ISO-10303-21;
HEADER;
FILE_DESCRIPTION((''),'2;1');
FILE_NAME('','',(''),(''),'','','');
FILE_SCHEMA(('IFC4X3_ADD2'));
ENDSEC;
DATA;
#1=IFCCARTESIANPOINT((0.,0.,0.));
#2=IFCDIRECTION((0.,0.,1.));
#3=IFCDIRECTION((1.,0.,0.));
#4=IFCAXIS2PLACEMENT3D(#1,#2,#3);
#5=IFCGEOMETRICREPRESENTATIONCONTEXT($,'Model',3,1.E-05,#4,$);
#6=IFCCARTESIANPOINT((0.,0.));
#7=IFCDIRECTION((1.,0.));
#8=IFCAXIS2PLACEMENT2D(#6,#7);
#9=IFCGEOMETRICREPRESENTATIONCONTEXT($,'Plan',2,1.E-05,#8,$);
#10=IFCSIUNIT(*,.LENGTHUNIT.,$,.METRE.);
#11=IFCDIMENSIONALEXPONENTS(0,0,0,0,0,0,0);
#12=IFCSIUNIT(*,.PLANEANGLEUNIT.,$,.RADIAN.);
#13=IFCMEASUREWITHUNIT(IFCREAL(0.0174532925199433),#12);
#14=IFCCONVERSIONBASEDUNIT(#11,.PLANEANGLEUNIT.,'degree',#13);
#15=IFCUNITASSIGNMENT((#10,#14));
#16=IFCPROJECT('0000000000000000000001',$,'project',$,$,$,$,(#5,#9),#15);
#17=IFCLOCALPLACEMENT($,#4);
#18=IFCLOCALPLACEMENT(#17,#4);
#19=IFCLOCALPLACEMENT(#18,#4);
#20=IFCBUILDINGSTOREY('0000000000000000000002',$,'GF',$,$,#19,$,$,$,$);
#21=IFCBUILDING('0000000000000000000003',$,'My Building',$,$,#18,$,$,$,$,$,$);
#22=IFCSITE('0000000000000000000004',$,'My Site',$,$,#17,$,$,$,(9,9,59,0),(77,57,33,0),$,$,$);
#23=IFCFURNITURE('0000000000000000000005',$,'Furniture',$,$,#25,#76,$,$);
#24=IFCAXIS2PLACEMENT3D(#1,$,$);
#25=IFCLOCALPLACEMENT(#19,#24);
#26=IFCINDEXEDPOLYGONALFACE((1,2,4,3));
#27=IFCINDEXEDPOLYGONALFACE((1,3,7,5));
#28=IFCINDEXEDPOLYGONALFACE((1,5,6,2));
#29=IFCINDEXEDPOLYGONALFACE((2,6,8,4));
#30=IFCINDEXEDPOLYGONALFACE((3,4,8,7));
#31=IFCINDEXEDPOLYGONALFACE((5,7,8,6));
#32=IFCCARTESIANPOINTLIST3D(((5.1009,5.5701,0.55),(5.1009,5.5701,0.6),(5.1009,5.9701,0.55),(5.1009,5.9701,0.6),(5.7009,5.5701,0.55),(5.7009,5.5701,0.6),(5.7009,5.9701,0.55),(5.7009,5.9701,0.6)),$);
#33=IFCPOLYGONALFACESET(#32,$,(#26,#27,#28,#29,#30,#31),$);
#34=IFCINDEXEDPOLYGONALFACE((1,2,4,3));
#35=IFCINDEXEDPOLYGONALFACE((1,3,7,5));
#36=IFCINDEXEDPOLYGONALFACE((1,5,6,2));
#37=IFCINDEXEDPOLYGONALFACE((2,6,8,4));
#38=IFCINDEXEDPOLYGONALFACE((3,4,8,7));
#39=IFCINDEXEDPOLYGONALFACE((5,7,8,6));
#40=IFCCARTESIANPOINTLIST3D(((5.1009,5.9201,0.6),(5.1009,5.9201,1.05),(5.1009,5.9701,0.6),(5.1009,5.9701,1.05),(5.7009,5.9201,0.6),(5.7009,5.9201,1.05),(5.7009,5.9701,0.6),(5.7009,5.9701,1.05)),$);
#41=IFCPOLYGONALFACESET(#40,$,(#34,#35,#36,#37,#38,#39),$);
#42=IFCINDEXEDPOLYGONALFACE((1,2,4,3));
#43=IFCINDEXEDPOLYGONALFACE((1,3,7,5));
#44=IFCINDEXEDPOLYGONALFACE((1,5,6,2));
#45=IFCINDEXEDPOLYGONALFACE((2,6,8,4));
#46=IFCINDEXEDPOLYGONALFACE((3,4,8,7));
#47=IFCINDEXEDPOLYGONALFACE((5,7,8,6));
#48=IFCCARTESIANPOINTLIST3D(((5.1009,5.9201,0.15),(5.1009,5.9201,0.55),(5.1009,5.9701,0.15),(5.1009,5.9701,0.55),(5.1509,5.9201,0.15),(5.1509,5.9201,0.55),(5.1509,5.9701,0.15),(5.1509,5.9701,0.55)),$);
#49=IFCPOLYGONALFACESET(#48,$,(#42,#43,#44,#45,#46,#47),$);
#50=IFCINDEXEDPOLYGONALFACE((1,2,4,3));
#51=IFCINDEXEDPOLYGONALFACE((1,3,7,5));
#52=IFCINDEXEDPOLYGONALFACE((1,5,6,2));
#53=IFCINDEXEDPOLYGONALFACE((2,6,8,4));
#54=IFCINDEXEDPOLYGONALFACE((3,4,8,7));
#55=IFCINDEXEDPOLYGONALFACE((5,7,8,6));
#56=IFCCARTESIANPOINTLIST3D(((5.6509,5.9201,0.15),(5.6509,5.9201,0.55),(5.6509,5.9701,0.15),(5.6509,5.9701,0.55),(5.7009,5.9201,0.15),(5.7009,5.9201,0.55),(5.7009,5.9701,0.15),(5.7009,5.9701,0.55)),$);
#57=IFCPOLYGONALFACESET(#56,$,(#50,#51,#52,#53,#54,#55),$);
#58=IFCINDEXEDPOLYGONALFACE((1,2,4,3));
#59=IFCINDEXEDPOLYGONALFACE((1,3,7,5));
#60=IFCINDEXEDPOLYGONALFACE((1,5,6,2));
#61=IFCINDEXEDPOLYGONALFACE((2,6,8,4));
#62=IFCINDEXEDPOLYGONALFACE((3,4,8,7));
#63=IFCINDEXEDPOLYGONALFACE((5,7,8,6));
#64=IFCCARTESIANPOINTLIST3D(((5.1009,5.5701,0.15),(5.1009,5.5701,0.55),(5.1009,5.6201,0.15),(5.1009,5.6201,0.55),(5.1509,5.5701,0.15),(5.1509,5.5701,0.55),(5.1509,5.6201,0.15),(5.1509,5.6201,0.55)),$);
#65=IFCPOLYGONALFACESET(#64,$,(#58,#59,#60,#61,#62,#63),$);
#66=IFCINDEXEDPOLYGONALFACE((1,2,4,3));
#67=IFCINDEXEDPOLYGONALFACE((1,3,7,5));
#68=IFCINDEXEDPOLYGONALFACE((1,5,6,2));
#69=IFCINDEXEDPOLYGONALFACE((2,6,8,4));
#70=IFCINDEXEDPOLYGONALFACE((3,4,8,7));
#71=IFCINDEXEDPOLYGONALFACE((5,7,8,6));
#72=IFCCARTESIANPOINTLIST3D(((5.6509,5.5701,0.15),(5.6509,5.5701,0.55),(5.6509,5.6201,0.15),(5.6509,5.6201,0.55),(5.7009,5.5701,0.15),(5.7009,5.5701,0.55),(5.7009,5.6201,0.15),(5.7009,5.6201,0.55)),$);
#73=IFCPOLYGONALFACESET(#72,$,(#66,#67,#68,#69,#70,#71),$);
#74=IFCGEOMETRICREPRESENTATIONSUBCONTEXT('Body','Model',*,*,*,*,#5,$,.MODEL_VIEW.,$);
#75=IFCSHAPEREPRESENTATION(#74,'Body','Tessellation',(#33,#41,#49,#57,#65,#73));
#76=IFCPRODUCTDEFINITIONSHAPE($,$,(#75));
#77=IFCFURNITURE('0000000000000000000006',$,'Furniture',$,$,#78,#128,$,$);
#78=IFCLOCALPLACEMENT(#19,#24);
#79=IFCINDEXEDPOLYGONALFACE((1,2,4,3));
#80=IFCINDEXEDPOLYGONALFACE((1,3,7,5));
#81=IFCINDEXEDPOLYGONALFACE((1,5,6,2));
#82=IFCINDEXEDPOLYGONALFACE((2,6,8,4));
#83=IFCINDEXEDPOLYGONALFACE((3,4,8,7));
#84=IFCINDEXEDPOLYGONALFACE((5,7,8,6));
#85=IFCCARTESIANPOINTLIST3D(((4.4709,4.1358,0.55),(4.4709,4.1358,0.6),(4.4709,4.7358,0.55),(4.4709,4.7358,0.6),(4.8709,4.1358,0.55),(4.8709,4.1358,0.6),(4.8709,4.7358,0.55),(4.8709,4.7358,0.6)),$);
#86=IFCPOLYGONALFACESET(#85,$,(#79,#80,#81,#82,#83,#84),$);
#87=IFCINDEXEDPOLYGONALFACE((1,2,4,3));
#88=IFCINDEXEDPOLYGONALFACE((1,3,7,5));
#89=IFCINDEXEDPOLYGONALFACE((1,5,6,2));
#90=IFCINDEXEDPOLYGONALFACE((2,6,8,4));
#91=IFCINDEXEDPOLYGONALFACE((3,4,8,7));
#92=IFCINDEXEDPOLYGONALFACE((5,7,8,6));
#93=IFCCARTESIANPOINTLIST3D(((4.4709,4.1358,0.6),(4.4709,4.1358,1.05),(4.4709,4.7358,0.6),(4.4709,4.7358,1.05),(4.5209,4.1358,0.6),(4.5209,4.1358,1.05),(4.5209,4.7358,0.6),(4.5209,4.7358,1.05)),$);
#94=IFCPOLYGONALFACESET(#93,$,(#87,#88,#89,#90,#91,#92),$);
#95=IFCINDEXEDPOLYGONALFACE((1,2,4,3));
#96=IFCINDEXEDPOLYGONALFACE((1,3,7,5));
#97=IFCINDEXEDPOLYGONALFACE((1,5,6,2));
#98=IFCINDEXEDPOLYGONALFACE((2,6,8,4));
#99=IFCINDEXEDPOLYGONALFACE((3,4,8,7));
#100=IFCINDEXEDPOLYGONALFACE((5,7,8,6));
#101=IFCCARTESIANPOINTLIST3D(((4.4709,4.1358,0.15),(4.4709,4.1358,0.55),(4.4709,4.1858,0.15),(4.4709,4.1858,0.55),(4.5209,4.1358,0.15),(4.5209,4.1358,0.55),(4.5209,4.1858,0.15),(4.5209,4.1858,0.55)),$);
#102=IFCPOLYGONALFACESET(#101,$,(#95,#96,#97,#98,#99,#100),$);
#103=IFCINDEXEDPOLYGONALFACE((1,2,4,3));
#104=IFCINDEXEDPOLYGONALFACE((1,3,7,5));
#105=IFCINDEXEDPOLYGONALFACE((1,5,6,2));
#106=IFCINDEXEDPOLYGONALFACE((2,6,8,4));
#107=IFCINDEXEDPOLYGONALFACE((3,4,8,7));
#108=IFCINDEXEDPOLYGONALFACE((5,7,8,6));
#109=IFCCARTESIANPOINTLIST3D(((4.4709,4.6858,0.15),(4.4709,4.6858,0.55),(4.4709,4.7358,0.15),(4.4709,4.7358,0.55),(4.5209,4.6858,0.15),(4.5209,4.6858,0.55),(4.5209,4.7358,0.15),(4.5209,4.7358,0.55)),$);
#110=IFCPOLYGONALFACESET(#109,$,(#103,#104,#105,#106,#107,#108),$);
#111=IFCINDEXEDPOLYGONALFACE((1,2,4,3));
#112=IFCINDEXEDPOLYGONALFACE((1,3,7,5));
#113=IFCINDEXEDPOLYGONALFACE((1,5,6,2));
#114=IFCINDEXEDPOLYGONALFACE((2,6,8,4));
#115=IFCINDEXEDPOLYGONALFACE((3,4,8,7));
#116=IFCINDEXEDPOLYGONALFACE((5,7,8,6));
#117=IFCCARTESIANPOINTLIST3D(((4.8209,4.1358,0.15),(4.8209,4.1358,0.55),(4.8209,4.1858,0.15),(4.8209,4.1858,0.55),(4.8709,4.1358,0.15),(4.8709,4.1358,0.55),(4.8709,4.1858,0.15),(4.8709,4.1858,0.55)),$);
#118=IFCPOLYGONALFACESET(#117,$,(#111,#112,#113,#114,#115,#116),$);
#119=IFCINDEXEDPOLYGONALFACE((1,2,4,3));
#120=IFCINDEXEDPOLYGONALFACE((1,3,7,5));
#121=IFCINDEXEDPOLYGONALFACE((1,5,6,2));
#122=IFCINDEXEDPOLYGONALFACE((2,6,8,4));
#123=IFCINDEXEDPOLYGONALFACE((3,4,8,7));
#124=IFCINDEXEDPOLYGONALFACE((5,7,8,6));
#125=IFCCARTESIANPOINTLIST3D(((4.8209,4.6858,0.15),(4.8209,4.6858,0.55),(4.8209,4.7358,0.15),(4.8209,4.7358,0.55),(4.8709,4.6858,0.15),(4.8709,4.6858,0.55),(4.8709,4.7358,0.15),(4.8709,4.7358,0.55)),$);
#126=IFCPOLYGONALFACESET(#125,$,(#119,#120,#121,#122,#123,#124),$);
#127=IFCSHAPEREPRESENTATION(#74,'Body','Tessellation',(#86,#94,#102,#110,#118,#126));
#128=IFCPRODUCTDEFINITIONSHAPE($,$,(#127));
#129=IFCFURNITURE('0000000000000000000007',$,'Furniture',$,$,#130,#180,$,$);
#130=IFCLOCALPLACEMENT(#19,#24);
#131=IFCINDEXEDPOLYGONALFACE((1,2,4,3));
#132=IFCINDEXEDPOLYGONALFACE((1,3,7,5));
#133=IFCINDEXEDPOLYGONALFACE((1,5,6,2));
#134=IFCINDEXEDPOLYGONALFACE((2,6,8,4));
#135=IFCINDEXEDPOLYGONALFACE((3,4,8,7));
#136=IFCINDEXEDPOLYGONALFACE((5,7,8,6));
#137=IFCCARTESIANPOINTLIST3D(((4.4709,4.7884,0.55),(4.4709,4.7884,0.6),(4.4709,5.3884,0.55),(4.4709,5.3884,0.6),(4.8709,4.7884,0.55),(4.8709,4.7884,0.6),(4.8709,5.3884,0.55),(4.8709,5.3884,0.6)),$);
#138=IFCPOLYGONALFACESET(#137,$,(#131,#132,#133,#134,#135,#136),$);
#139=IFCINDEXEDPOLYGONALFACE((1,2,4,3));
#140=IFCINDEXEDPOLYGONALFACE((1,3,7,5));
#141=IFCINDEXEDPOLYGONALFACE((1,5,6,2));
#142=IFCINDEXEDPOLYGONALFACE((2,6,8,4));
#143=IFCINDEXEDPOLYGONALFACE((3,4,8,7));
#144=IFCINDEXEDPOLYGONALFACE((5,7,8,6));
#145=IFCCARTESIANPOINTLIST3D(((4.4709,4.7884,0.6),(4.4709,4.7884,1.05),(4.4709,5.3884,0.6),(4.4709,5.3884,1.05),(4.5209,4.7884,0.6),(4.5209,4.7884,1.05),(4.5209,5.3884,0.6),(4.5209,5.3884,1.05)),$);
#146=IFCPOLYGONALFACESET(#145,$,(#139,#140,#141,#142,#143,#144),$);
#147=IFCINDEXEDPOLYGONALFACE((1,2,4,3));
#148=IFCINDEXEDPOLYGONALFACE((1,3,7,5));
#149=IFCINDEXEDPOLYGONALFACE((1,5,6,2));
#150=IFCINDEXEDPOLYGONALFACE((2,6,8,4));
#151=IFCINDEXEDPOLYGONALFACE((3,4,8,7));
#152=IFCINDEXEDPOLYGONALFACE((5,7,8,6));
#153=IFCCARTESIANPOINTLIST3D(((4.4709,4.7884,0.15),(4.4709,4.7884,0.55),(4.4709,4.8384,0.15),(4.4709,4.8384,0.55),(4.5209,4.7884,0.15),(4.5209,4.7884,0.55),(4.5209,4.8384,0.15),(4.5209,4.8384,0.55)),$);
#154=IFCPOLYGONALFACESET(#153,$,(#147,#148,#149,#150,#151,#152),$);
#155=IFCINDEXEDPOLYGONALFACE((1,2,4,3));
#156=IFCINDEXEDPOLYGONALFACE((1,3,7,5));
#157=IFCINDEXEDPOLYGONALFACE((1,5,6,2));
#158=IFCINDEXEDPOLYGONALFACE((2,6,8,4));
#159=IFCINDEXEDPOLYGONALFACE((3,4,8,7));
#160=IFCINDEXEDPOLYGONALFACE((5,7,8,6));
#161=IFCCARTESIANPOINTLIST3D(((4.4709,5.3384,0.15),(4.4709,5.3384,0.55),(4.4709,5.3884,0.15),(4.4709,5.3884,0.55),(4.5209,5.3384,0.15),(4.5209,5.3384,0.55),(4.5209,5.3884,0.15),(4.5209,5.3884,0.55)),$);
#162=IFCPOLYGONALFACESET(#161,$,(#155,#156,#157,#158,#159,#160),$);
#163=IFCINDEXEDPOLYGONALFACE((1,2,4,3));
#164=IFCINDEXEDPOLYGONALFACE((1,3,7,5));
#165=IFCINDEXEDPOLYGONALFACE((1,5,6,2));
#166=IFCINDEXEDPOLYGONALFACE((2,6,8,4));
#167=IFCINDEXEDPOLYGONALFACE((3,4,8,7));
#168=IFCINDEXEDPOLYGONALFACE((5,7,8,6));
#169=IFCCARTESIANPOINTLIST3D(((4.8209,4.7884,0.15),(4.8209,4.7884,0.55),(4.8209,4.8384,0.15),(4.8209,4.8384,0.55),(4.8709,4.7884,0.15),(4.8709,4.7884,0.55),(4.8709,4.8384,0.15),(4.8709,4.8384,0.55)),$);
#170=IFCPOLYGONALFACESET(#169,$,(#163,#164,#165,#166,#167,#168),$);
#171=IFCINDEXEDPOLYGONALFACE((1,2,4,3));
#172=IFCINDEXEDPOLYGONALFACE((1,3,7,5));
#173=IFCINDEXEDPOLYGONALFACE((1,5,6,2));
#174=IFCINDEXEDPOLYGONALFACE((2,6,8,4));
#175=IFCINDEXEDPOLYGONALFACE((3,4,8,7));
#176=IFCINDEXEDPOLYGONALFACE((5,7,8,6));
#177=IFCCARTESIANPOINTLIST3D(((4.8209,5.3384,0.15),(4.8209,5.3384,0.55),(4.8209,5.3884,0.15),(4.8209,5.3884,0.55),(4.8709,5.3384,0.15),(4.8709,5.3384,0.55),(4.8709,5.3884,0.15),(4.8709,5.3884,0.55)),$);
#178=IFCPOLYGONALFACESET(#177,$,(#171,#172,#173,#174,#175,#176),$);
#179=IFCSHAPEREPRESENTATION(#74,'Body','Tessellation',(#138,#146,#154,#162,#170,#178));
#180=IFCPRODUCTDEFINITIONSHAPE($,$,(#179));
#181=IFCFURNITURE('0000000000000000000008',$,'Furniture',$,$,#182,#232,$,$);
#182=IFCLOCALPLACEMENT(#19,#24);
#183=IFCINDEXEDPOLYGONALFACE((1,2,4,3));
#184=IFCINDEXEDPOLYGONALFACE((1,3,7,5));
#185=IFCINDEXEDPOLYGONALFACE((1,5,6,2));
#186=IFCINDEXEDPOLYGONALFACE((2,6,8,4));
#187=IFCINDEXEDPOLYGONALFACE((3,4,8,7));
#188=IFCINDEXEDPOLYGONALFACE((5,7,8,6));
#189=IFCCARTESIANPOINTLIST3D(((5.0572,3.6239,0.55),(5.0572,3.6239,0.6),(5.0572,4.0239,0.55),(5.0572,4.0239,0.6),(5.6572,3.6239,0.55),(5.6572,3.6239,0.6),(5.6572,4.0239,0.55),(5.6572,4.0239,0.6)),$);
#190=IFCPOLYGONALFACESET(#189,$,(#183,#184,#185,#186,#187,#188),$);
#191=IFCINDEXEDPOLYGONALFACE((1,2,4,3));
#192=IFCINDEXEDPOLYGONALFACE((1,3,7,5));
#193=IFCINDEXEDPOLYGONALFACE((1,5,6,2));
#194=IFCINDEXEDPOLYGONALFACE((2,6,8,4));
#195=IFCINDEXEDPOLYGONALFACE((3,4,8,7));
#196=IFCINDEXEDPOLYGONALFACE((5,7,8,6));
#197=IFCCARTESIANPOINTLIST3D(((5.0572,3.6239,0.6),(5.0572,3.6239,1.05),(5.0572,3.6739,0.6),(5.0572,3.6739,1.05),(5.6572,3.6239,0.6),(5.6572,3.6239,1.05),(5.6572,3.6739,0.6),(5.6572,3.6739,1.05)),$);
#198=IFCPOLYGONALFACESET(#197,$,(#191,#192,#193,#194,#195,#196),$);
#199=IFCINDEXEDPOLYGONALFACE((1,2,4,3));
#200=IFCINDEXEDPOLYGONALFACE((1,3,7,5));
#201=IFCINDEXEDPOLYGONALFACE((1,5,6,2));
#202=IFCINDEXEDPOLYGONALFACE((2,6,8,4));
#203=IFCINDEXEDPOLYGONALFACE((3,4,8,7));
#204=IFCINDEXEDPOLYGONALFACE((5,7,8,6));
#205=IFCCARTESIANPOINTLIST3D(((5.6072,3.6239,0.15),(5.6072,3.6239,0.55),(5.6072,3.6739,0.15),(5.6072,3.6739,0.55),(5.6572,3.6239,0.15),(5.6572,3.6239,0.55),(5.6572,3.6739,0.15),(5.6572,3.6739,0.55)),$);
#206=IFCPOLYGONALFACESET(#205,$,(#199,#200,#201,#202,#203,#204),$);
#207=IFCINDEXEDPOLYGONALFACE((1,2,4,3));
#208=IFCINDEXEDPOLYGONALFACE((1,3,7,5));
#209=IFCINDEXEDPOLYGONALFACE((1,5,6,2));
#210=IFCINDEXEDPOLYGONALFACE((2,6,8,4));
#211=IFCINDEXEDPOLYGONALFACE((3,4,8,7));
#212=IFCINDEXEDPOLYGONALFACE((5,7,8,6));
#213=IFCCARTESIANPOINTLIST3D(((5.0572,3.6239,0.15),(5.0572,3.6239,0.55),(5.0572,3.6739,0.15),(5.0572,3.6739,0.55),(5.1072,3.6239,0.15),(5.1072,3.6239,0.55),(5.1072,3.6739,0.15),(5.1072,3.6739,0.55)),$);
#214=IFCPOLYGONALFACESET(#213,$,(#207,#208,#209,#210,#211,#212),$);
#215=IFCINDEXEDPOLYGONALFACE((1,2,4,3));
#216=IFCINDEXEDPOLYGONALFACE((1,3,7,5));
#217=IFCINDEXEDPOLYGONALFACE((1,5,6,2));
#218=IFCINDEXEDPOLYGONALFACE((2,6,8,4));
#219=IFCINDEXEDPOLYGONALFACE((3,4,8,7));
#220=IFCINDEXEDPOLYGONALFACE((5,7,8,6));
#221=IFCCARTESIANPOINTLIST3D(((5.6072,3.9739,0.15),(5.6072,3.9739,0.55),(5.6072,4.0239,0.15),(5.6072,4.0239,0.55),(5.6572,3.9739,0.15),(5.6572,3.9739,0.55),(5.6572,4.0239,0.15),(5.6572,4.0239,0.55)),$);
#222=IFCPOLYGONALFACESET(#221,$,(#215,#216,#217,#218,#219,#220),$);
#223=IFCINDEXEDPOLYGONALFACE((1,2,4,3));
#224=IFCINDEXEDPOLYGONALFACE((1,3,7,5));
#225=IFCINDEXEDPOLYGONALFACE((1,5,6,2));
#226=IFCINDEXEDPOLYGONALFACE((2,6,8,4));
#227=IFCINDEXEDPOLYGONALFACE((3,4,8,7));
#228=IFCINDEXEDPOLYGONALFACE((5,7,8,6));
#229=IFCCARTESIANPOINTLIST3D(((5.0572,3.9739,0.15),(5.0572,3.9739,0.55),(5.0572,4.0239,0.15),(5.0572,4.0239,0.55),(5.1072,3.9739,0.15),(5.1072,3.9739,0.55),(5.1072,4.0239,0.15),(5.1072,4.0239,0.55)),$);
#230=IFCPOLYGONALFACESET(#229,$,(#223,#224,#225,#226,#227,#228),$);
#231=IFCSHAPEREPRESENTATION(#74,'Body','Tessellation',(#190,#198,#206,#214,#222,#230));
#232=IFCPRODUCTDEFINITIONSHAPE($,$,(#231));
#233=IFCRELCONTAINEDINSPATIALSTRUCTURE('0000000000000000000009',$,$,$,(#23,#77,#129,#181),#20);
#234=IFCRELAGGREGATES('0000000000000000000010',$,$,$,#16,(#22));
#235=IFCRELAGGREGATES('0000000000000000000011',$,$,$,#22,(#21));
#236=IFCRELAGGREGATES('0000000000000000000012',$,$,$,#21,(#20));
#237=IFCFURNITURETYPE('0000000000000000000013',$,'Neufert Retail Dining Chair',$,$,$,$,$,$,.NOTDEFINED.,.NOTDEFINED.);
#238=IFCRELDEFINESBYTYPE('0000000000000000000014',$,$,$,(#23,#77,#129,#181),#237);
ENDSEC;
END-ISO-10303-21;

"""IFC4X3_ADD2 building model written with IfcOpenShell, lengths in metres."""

from ifc_helpers import new_model, entity, si_unit, converted_unit, frame, origin_with_axes, origin_2d_with_axis, place, context, subcontext, project, spatial, line, indexed_curve, outline, extrude, shape, source, transform, mapped, type_object, type_shapes, element, save


model = new_model("IFC4X3_ADD2")

# Units and contexts
model_context = context("Model", 3, precision=1e-05, world=origin_with_axes())
plan_context = context("Plan", 2, precision=1e-05, world=origin_2d_with_axis())
body_context_1 = subcontext(model_context, "Body", "Model", "MODEL_VIEW")
body_context_2 = subcontext(plan_context, "Body", "Plan", "PLAN_VIEW")
ifc_project = project(units=[si_unit("LENGTHUNIT", "METRE"), converted_unit("PLANEANGLEUNIT", "degree", entity("IfcReal", 0.0174532925199433), si_unit("PLANEANGLEUNIT", "RADIAN"), dimensions=[0, 0, 0, 0, 0, 0, 0])], contexts=[model_context, plan_context])

# Site, building, storey
site_placement = place(None, origin_with_axes())
site = spatial("IfcSite", under=ifc_project, at=site_placement, Name="My Site", RefLatitude=(9, 9, 59, 0), RefLongitude=(77, 57, 33, 0))
building_placement = place(site_placement, origin_with_axes())
building = spatial("IfcBuilding", under=site, at=building_placement, Name="My Building")
storey_placement = place(building_placement, origin_with_axes())
storey = spatial("IfcBuildingStorey", under=building, at=storey_placement, Name="GF")

# Furniture
furniture_type = type_object("IfcFurnitureType", Name="Neufert Retail Dining Chair", AssemblyPlace="NOTDEFINED", PredefinedType="NOTDEFINED")
shared_shape_1 = source(origin_with_axes(), body_context_1, "Body", "SweptSolid", [
    extrude(outline(indexed_curve([(-0.3, 0.0), (0.3, 0.0), (0.3, -0.4), (-0.3, -0.4)], segments=[line(1, 2, 3, 4, 1)])), frame((0.0, 0.0, 0.45), z_axis=(0.0, 0.0, 1.0), x_axis=(1.0, 0.0, 0.0)), (0.0, 0.0, -1.0), 0.05),
    extrude(outline(indexed_curve([(-0.3, 0.0), (0.3, 0.0), (0.3, -0.05), (-0.3, -0.05)], segments=[line(1, 2, 3, 4, 1)])), frame((0.0, 0.0, 0.9), z_axis=(0.0, 0.0, 1.0), x_axis=(1.0, 0.0, 0.0)), (0.0, 0.0, -1.0), 0.45),
    extrude(outline(indexed_curve([(-0.3, 0.0), (-0.25, 0.0), (-0.25, -0.05), (-0.3, -0.05)], segments=[line(1, 2, 3, 4, 1)])), origin_with_axes(), (0.0, 0.0, 1.0), 0.4),
    extrude(outline(indexed_curve([(0.3, 0.0), (0.25, 0.0), (0.25, -0.05), (0.3, -0.05)], segments=[line(1, 2, 3, 4, 1)])), origin_with_axes(), (0.0, 0.0, 1.0), 0.4),
    extrude(outline(indexed_curve([(-0.3, -0.4), (-0.25, -0.4), (-0.25, -0.35), (-0.3, -0.35)], segments=[line(1, 2, 3, 4, 1)])), origin_with_axes(), (0.0, 0.0, 1.0), 0.4),
    extrude(outline(indexed_curve([(0.3, -0.4), (0.25, -0.4), (0.25, -0.35), (0.3, -0.35)], segments=[line(1, 2, 3, 4, 1)])), origin_with_axes(), (0.0, 0.0, 1.0), 0.4),
])
shared_shape_2 = source(origin_with_axes(), body_context_2, "Body", "Curve2D", [
    entity("IfcIndexedPolyCurve", entity("IfcCartesianPointList2D", [[-0.3, -0.4], [0.3, -0.4]])),
    entity("IfcIndexedPolyCurve", entity("IfcCartesianPointList2D", [[-0.3, -0.4], [-0.3, -0.3], [-0.2121, -0.0879], [0.0, 0.0], [0.2121, -0.0879], [0.3, -0.3], [0.3, -0.4]]), [entity("IfcLineIndex", [1, 2]), entity("IfcArcIndex", [2, 3, 4]), entity("IfcArcIndex", [4, 5, 6]), entity("IfcLineIndex", [6, 7])]),
    entity("IfcIndexedPolyCurve", entity("IfcCartesianPointList2D", [[-0.26, -0.4], [-0.26, -0.3], [-0.1838, -0.1162], [0.0, -0.04], [0.1838, -0.1162], [0.26, -0.3], [0.26, -0.4]]), [entity("IfcLineIndex", [1, 2]), entity("IfcArcIndex", [2, 3, 4]), entity("IfcArcIndex", [4, 5, 6]), entity("IfcLineIndex", [6, 7])]),
])
type_shapes(furniture_type, [shared_shape_1, shared_shape_2])
for number, where, z_axis, x_axis, name in (
    (1, (5.4009, 5.9701, 0.15), (0.0, 0.0, 1.0), (1.0, -0.000001, 0.0), "Furniture"),
    (2, (4.4709, 4.4358, 0.15), (0.0, 0.0, 1.0), (0.000002, 1.0, 0.0), "Furniture"),
    (3, (4.4709, 5.0884, 0.15), (0.0, 0.0, 1.0), (0.000002, 1.0, 0.0), "Furniture"),
    (4, (5.3572, 3.6239, 0.15), (0.0, 0.0, 1.0), (-1.0, 0.000002, 0.0), "Furniture"),
):
    element("IfcFurniture", number, at=place(storey_placement, frame(where, z_axis=z_axis, x_axis=x_axis)), inside=storey, type_object=furniture_type, Name=name, shapes=[
        shape(body_context_1, "Body", "MappedRepresentation", [mapped(shared_shape_1, transform((0.0, 0.0, 0.0), x_axis=(1.0, 0.0, 0.0), y_axis=(0.0, 1.0, 0.0), z_axis=(0.0, 0.0, 1.0), scale=1.0))]),
        shape(body_context_2, "Body", "MappedRepresentation", [mapped(shared_shape_2, transform((0.0, 0.0, 0.0), x_axis=(1.0, 0.0, 0.0), y_axis=(0.0, 1.0, 0.0), z_axis=(0.0, 0.0, 1.0), scale=1.0))]),
    ])

save(model, "model.ifc")
